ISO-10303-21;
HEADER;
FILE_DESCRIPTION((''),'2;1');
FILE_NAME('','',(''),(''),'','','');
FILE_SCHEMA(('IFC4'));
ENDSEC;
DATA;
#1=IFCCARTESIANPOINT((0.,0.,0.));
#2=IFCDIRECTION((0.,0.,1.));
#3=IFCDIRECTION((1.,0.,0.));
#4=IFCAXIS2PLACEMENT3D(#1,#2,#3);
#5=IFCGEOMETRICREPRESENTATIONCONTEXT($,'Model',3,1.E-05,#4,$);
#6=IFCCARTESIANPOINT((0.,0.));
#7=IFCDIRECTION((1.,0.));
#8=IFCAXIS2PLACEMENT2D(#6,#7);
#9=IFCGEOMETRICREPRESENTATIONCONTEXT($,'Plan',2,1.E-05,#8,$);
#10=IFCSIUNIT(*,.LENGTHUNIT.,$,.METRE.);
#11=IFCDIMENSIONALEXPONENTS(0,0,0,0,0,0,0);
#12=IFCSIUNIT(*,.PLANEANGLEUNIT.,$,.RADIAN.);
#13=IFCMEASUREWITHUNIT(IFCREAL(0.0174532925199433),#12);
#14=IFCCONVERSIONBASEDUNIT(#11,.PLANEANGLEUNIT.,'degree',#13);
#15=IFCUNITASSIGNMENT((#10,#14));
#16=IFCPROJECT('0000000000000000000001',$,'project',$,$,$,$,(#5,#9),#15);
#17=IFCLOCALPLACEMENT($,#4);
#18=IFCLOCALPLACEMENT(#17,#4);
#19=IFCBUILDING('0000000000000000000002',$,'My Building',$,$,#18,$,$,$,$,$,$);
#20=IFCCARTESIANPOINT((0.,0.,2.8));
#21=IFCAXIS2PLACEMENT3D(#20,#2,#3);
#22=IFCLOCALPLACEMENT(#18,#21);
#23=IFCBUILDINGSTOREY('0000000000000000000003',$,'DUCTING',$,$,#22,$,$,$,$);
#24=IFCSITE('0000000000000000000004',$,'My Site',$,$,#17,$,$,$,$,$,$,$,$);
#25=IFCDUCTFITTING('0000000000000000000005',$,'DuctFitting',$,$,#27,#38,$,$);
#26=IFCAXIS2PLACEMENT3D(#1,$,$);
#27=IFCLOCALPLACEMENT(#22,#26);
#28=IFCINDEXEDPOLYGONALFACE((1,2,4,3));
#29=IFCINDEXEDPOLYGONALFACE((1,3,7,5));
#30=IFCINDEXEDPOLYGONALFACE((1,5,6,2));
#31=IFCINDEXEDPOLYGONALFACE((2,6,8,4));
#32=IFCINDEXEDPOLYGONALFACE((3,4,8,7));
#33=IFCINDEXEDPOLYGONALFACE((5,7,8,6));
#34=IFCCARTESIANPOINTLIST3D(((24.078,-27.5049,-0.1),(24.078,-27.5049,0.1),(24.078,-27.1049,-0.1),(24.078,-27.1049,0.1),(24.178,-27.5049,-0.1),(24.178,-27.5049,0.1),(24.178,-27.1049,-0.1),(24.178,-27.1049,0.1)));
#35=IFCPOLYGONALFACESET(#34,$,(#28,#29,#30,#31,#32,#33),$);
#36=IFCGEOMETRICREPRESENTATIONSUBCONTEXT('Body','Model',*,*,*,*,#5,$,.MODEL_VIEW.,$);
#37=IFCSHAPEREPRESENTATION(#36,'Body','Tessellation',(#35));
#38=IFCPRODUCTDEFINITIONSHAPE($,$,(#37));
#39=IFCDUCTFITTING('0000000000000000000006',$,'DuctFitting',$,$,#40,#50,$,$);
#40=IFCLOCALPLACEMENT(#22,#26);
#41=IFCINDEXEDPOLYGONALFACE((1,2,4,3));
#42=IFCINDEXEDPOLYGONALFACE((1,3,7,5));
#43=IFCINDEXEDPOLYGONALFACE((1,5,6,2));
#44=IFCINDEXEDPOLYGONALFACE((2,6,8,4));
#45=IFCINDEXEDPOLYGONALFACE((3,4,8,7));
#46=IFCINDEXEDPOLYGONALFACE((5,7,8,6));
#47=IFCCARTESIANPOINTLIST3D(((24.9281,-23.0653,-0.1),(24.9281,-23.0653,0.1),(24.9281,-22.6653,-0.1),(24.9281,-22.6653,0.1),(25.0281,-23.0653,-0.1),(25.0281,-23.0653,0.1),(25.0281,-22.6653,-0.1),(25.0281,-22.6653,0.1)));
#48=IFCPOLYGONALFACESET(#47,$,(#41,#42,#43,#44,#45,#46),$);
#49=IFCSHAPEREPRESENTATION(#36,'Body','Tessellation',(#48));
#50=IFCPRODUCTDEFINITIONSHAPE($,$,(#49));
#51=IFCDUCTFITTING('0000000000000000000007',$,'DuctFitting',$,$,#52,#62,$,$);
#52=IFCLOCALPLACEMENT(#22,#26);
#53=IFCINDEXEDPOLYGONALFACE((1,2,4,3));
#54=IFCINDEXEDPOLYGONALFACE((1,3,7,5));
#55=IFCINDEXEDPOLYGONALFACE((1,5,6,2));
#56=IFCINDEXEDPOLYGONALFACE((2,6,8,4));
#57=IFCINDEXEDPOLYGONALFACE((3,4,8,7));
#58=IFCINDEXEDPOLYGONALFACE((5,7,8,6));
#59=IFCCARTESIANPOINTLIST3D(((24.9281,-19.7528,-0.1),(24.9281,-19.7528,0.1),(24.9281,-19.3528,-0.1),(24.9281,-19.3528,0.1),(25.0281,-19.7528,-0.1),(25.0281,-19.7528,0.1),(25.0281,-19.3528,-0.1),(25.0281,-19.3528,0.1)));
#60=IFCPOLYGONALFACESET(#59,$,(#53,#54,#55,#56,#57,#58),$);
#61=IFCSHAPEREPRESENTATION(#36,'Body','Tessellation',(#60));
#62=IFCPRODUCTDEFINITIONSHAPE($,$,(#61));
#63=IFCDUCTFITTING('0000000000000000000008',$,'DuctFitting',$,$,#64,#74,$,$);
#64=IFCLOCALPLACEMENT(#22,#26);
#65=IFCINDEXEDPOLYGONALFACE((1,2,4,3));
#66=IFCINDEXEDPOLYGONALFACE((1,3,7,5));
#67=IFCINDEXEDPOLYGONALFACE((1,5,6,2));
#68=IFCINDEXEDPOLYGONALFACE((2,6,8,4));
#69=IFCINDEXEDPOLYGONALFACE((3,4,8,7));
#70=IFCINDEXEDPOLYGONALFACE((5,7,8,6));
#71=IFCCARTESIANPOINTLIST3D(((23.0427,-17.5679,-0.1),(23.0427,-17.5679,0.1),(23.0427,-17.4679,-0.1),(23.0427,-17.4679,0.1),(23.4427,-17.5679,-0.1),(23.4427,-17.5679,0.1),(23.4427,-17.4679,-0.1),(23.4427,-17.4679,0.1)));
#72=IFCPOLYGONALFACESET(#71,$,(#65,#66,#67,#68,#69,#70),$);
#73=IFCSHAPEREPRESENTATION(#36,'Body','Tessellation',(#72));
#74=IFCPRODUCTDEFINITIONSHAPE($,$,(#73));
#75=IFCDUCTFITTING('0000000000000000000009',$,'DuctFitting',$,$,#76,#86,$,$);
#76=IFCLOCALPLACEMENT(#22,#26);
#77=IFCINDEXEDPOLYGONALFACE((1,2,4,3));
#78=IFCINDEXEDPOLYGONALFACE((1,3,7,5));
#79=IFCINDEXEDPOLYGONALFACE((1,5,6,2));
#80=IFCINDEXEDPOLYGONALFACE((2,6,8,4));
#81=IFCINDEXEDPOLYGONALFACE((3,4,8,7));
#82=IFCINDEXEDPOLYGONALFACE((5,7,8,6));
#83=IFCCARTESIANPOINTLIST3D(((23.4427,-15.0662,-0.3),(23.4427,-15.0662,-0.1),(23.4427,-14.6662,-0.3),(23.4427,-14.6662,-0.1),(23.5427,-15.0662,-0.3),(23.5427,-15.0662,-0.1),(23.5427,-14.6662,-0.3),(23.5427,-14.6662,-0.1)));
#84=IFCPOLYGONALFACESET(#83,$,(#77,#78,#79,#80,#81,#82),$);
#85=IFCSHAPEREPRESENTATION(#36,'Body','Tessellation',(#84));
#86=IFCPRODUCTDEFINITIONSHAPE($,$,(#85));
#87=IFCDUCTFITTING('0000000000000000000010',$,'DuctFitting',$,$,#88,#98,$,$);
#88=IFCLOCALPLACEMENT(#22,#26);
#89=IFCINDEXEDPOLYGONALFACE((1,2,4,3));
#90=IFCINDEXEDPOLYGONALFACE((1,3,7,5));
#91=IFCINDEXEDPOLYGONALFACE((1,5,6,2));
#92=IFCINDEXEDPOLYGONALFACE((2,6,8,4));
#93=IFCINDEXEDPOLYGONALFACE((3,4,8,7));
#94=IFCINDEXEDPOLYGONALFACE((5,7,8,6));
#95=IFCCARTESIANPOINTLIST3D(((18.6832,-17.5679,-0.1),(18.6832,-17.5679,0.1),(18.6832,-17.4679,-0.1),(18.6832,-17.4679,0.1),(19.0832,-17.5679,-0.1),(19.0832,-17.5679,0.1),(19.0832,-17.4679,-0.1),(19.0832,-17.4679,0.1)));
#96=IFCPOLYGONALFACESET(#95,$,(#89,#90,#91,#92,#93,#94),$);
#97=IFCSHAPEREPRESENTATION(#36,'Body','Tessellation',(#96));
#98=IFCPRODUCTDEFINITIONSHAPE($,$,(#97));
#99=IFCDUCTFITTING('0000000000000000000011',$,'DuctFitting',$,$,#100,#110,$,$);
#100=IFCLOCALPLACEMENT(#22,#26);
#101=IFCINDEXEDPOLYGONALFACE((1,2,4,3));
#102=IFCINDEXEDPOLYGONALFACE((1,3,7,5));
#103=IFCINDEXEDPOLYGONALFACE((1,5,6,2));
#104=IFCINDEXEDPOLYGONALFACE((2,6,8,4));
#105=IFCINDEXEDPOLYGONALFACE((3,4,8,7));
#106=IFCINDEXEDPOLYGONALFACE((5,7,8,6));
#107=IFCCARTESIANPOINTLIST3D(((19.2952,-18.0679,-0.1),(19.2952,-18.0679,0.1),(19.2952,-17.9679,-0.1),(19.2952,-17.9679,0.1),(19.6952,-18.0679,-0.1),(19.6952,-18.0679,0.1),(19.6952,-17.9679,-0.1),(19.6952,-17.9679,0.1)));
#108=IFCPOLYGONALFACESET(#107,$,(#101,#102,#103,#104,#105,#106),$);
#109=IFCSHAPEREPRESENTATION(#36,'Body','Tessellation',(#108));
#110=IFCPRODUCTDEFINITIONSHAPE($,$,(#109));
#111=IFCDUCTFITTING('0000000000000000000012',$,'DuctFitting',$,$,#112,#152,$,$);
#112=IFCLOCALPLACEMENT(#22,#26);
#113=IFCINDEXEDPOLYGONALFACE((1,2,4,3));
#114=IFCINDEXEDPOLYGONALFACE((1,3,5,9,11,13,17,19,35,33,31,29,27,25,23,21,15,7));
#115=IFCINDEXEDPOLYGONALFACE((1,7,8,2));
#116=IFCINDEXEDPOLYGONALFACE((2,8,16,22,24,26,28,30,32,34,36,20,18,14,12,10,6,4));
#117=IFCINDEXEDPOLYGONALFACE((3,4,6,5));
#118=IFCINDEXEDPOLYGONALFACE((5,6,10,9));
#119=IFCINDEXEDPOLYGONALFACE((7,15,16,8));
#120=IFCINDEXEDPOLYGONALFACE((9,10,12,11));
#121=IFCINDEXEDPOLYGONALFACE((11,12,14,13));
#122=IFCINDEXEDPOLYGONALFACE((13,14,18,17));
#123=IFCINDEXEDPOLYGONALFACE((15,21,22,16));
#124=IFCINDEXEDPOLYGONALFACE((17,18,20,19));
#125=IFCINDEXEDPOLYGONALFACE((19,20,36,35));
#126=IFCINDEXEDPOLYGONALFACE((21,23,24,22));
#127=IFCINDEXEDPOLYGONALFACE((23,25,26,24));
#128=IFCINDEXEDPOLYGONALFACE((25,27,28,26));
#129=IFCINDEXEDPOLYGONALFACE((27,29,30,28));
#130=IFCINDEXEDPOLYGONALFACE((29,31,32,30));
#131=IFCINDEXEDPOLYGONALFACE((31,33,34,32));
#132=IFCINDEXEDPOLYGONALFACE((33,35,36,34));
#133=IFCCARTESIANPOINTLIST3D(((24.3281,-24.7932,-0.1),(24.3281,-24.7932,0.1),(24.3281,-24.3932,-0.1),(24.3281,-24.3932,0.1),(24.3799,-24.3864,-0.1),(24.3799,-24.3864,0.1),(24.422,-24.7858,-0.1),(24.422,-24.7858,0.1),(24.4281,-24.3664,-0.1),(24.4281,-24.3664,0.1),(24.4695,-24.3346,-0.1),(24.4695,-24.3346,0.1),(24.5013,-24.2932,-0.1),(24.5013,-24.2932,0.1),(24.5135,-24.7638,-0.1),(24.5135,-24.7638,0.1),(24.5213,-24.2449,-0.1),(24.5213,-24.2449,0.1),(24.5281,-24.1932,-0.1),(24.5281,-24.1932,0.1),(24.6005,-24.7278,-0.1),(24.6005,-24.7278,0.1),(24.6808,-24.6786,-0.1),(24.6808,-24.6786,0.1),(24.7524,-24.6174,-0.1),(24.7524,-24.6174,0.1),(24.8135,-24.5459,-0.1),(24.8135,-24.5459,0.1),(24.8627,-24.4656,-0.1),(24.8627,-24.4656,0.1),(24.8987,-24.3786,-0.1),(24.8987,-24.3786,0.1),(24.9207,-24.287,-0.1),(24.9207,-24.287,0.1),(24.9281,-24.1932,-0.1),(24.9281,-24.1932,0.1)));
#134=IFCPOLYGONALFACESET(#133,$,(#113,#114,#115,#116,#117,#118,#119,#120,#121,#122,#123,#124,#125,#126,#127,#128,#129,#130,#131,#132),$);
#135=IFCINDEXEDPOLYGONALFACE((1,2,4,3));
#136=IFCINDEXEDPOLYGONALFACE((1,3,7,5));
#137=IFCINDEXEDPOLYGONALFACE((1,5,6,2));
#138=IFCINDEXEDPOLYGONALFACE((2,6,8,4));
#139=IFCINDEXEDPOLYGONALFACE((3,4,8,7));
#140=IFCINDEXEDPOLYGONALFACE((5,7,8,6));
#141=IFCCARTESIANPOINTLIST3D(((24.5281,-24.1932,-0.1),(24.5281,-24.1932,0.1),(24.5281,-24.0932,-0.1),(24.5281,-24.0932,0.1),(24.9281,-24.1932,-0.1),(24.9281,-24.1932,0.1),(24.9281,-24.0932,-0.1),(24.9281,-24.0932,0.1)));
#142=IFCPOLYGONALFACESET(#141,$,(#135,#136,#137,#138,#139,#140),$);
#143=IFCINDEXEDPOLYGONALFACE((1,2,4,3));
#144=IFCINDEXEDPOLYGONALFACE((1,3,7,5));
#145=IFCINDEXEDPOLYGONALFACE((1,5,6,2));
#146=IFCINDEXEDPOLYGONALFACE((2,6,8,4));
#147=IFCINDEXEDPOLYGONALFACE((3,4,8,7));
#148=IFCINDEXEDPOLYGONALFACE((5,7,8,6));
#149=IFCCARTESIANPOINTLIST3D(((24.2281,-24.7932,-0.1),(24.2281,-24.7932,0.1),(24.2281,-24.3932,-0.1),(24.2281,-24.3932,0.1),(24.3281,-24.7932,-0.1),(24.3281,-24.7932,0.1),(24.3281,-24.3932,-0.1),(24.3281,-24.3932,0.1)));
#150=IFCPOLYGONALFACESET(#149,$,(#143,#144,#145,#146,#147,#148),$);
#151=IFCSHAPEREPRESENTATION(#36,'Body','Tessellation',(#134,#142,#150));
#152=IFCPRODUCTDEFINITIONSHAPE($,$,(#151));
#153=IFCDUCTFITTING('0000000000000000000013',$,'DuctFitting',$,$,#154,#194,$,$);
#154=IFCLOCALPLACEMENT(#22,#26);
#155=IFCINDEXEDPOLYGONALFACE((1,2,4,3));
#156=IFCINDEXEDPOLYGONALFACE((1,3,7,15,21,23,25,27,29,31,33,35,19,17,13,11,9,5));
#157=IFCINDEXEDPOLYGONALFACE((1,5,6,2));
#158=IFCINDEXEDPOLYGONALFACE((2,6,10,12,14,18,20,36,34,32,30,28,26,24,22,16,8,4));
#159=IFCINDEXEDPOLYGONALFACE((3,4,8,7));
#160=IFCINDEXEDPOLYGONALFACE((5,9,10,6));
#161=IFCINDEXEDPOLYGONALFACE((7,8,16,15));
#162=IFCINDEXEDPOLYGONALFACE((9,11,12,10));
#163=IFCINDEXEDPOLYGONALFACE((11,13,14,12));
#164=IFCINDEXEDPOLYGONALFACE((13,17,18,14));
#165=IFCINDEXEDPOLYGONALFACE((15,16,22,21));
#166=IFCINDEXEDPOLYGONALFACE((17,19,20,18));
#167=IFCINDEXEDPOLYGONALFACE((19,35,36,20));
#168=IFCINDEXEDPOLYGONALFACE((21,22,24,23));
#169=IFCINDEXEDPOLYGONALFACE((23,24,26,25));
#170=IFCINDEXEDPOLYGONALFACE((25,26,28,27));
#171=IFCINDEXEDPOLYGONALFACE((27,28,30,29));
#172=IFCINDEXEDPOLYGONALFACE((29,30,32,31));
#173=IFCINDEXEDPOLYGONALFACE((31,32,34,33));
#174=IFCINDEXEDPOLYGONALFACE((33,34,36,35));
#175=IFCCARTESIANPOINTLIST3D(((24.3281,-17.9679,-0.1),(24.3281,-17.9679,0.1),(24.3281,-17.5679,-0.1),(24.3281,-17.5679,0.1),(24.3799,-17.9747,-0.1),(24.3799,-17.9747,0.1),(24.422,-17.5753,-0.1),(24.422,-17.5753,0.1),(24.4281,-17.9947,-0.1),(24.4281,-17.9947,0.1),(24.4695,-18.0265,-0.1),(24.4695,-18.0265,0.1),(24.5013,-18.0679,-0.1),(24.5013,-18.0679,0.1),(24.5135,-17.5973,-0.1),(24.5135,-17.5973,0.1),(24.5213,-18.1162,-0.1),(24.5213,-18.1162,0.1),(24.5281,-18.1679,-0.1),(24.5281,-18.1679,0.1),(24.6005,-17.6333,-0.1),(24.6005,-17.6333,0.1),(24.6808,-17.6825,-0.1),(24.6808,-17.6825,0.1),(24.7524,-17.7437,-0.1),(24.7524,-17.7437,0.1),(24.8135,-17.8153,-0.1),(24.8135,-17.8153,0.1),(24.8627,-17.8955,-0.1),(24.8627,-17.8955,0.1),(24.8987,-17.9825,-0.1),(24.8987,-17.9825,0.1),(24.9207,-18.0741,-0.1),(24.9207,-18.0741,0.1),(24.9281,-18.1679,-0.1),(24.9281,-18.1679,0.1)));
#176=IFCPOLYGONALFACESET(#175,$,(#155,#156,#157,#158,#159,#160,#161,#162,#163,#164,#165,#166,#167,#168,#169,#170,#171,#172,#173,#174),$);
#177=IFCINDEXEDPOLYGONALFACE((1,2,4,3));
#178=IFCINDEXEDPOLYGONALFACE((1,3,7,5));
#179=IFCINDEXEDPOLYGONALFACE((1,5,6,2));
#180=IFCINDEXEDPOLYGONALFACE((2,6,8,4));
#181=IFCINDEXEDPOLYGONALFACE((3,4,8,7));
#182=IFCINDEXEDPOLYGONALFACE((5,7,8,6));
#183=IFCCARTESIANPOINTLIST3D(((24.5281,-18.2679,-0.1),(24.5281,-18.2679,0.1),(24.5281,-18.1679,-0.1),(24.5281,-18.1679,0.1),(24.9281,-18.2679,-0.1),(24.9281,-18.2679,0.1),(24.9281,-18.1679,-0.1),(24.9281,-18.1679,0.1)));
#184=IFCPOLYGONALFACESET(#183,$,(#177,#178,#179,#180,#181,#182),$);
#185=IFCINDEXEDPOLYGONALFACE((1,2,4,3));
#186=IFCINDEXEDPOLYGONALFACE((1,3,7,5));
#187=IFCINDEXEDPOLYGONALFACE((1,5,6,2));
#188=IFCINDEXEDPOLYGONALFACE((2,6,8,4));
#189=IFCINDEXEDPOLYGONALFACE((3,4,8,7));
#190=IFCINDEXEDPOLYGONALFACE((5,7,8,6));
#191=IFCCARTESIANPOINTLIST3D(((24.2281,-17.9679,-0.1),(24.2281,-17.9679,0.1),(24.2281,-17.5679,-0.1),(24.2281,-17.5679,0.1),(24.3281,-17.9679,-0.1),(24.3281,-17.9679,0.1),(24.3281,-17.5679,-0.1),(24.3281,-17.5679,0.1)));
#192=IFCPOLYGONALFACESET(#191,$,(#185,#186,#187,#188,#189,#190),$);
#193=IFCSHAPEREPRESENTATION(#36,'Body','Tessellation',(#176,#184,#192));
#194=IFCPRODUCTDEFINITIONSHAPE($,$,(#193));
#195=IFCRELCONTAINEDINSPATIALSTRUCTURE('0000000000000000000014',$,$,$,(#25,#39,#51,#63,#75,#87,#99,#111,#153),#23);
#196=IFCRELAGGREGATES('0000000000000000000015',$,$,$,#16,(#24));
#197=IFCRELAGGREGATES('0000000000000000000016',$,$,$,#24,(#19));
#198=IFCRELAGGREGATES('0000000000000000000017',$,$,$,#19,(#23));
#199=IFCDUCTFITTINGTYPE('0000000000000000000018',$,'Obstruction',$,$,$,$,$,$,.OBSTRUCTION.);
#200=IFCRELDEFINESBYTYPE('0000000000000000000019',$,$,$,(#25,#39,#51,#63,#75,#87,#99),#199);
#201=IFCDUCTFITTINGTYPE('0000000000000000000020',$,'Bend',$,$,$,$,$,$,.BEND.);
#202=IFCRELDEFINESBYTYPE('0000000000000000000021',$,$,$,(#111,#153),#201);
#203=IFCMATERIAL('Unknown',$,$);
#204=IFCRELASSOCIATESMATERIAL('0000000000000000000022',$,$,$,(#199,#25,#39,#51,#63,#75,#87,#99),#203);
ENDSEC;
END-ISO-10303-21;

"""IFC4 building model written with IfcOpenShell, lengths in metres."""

from ifc_helpers import new_model, entity, si_unit, converted_unit, frame, origin_with_axes, origin_2d_with_axis, place, context, subcontext, project, spatial, line, arc, indexed_curve, rectangle, outline, extrude, source, transform, mapped, material, material_profile, profile_set, profile_usage, type_object, type_shapes, element, save


model = new_model("IFC4")

# Units and contexts
model_context = context("Model", 3, precision=1e-05, world=origin_with_axes())
plan_context = context("Plan", 2, precision=1e-05, world=origin_2d_with_axis())
body_context = subcontext(model_context, "Body", "Model", "MODEL_VIEW")
ifc_project = project(units=[si_unit("LENGTHUNIT", "METRE"), converted_unit("PLANEANGLEUNIT", "degree", entity("IfcReal", 0.0174532925199433), si_unit("PLANEANGLEUNIT", "RADIAN"), dimensions=[0, 0, 0, 0, 0, 0, 0])], contexts=[model_context, plan_context])

# Site, building, storey
site_placement = place(None, origin_with_axes())
site = spatial("IfcSite", under=ifc_project, at=site_placement, Name="My Site")
building_placement = place(site_placement, origin_with_axes())
building = spatial("IfcBuilding", under=site, at=building_placement, Name="My Building")
storey_placement = place(building_placement, frame((0.0, 0.0, 2.8), z_axis=(0.0, 0.0, 1.0), x_axis=(1.0, 0.0, 0.0)))
storey = spatial("IfcBuildingStorey", under=building, at=storey_placement, Name="DUCTING")

# Shared definitions
ifc_material = material(Name="Unknown")

# Duct fittings
ifc_material_profile_1 = material_profile(ifc_material, rectangle(XDim=0.4, YDim=0.2))
ifc_profile_set_1 = profile_set([ifc_material_profile_1])
duct_fitting_type_1 = type_object("IfcDuctFittingType", Name="Obstruction", PredefinedType="OBSTRUCTION", material=ifc_profile_set_1)
ifc_profile_usage_1 = profile_usage(ifc_profile_set_1, cardinal=5)
duct_fitting_1_placement = place(storey_placement, frame((24.178, -27.3049, 0.0), z_axis=(-1.0, 0.0, -0.000001), x_axis=(0.0, -1.0, 0.0)))
element("IfcDuctFitting", 1, at=duct_fitting_1_placement, inside=storey, type_object=duct_fitting_type_1, material=ifc_profile_usage_1, Name="DuctFitting", context=body_context, shape_type="SweptSolid", body=[
    extrude(rectangle(XDim=0.4, YDim=0.2), origin_with_axes(), (0.0, 0.0, 1.0), 0.1),
])
ifc_profile_usage_2 = profile_usage(ifc_profile_set_1, cardinal=5)
duct_fitting_2_placement = place(storey_placement, frame((25.0281, -22.8653, 0.0), z_axis=(-1.0, 0.0, -0.000001), x_axis=(0.0, -1.0, 0.0)))
element("IfcDuctFitting", 2, at=duct_fitting_2_placement, inside=storey, type_object=duct_fitting_type_1, material=ifc_profile_usage_2, Name="DuctFitting", context=body_context, shape_type="SweptSolid", body=[
    extrude(rectangle(XDim=0.4, YDim=0.2), origin_with_axes(), (0.0, 0.0, 1.0), 0.1),
])
ifc_profile_usage_3 = profile_usage(ifc_profile_set_1, cardinal=5)
duct_fitting_3_placement = place(storey_placement, frame((25.0281, -19.5528, 0.0), z_axis=(-1.0, 0.0, -0.000001), x_axis=(0.0, -1.0, 0.0)))
element("IfcDuctFitting", 3, at=duct_fitting_3_placement, inside=storey, type_object=duct_fitting_type_1, material=ifc_profile_usage_3, Name="DuctFitting", context=body_context, shape_type="SweptSolid", body=[
    extrude(rectangle(XDim=0.4, YDim=0.2), origin_with_axes(), (0.0, 0.0, 1.0), 0.1),
])
ifc_profile_usage_4 = profile_usage(ifc_profile_set_1, cardinal=5)
duct_fitting_4_placement = place(storey_placement, frame((23.2427, -17.4679, 0.0), z_axis=(0.0, -1.0, 0.0), x_axis=(1.0, 0.0, 0.0)))
element("IfcDuctFitting", 4, at=duct_fitting_4_placement, inside=storey, type_object=duct_fitting_type_1, material=ifc_profile_usage_4, Name="DuctFitting", context=body_context, shape_type="SweptSolid", body=[
    extrude(rectangle(XDim=0.4, YDim=0.2), origin_with_axes(), (0.0, 0.0, 1.0), 0.1),
])
ifc_profile_usage_5 = profile_usage(ifc_profile_set_1, cardinal=5)
duct_fitting_5_placement = place(storey_placement, frame((23.5427, -14.8662, -0.2), z_axis=(-1.0, 0.0, -0.000001), x_axis=(0.0, -1.0, 0.0)))
element("IfcDuctFitting", 5, at=duct_fitting_5_placement, inside=storey, type_object=duct_fitting_type_1, material=ifc_profile_usage_5, Name="DuctFitting", context=body_context, shape_type="SweptSolid", body=[
    extrude(rectangle(XDim=0.4, YDim=0.2), origin_with_axes(), (0.0, 0.0, 1.0), 0.1),
])
ifc_profile_usage_6 = profile_usage(ifc_profile_set_1, cardinal=5)
duct_fitting_6_placement = place(storey_placement, frame((18.8832, -17.4679, 0.0), z_axis=(0.0, -1.0, 0.0), x_axis=(1.0, 0.0, 0.0)))
element("IfcDuctFitting", 6, at=duct_fitting_6_placement, inside=storey, type_object=duct_fitting_type_1, material=ifc_profile_usage_6, Name="DuctFitting", context=body_context, shape_type="SweptSolid", body=[
    extrude(rectangle(XDim=0.4, YDim=0.2), origin_with_axes(), (0.0, 0.0, 1.0), 0.1),
])
ifc_profile_usage_7 = profile_usage(ifc_profile_set_1, cardinal=5)
duct_fitting_7_placement = place(storey_placement, frame((19.4952, -18.0679, 0.0), z_axis=(0.0, 1.0, 0.0), x_axis=(-1.0, 0.0, 0.0)))
element("IfcDuctFitting", 7, at=duct_fitting_7_placement, inside=storey, type_object=duct_fitting_type_1, material=ifc_profile_usage_7, Name="DuctFitting", context=body_context, shape_type="SweptSolid", body=[
    extrude(rectangle(XDim=0.4, YDim=0.2), origin_with_axes(), (0.0, 0.0, 1.0), 0.1),
])
duct_fitting_type_2 = type_object("IfcDuctFittingType", Name="Bend", PredefinedType="BEND")
shared_shape = source(origin_with_axes(), body_context, "Body", "SweptSolid", [
    extrude(outline(indexed_curve([(0.2, 0.0), (0.2586, -0.1414), (0.4, -0.2), (0.4, -0.6), (-0.0243, -0.4243), (-0.2, 0.0)], segments=[arc(1, 2, 3), line(3, 4), arc(4, 5, 6), line(6, 1)])), frame((0.0, -0.1, -0.1), z_axis=(0.0, -1.0, 0.0), x_axis=(1.0, 0.0, 0.0)), (0.0, 0.0, -1.0), 0.2),
    extrude(rectangle(XDim=0.4, YDim=0.2), origin_with_axes(), (0.0, 0.0, -1.0), 0.1),
    extrude(rectangle(XDim=0.4, YDim=0.2), frame((0.4, 0.0, -0.5), z_axis=(1.0, 0.0, 0.0), x_axis=(0.0, 0.0, 1.0)), (0.0, 0.0, 1.0), 0.1),
])
type_shapes(duct_fitting_type_2, [shared_shape])
for number, where, z_axis, x_axis, name in (
    (8, (24.7281, -24.0932, 0.0), (0.0, 1.0, 0.0), (-1.0, 0.0, 0.0), "DuctFitting"),
    (9, (24.7281, -18.2679, 0.0), (0.0, -1.0, 0.0), (-1.0, 0.0, 0.0), "DuctFitting"),
):
    element("IfcDuctFitting", number, at=place(storey_placement, frame(where, z_axis=z_axis, x_axis=x_axis)), inside=storey, type_object=duct_fitting_type_2, Name=name, context=body_context, shape_type="MappedRepresentation", body=[
        mapped(shared_shape, transform((0.0, 0.0, 0.0), x_axis=(1.0, 0.0, 0.0), y_axis=(0.0, 1.0, 0.0), z_axis=(0.0, 0.0, 1.0), scale=1.0)),
    ])

save(model, "model.ifc")
